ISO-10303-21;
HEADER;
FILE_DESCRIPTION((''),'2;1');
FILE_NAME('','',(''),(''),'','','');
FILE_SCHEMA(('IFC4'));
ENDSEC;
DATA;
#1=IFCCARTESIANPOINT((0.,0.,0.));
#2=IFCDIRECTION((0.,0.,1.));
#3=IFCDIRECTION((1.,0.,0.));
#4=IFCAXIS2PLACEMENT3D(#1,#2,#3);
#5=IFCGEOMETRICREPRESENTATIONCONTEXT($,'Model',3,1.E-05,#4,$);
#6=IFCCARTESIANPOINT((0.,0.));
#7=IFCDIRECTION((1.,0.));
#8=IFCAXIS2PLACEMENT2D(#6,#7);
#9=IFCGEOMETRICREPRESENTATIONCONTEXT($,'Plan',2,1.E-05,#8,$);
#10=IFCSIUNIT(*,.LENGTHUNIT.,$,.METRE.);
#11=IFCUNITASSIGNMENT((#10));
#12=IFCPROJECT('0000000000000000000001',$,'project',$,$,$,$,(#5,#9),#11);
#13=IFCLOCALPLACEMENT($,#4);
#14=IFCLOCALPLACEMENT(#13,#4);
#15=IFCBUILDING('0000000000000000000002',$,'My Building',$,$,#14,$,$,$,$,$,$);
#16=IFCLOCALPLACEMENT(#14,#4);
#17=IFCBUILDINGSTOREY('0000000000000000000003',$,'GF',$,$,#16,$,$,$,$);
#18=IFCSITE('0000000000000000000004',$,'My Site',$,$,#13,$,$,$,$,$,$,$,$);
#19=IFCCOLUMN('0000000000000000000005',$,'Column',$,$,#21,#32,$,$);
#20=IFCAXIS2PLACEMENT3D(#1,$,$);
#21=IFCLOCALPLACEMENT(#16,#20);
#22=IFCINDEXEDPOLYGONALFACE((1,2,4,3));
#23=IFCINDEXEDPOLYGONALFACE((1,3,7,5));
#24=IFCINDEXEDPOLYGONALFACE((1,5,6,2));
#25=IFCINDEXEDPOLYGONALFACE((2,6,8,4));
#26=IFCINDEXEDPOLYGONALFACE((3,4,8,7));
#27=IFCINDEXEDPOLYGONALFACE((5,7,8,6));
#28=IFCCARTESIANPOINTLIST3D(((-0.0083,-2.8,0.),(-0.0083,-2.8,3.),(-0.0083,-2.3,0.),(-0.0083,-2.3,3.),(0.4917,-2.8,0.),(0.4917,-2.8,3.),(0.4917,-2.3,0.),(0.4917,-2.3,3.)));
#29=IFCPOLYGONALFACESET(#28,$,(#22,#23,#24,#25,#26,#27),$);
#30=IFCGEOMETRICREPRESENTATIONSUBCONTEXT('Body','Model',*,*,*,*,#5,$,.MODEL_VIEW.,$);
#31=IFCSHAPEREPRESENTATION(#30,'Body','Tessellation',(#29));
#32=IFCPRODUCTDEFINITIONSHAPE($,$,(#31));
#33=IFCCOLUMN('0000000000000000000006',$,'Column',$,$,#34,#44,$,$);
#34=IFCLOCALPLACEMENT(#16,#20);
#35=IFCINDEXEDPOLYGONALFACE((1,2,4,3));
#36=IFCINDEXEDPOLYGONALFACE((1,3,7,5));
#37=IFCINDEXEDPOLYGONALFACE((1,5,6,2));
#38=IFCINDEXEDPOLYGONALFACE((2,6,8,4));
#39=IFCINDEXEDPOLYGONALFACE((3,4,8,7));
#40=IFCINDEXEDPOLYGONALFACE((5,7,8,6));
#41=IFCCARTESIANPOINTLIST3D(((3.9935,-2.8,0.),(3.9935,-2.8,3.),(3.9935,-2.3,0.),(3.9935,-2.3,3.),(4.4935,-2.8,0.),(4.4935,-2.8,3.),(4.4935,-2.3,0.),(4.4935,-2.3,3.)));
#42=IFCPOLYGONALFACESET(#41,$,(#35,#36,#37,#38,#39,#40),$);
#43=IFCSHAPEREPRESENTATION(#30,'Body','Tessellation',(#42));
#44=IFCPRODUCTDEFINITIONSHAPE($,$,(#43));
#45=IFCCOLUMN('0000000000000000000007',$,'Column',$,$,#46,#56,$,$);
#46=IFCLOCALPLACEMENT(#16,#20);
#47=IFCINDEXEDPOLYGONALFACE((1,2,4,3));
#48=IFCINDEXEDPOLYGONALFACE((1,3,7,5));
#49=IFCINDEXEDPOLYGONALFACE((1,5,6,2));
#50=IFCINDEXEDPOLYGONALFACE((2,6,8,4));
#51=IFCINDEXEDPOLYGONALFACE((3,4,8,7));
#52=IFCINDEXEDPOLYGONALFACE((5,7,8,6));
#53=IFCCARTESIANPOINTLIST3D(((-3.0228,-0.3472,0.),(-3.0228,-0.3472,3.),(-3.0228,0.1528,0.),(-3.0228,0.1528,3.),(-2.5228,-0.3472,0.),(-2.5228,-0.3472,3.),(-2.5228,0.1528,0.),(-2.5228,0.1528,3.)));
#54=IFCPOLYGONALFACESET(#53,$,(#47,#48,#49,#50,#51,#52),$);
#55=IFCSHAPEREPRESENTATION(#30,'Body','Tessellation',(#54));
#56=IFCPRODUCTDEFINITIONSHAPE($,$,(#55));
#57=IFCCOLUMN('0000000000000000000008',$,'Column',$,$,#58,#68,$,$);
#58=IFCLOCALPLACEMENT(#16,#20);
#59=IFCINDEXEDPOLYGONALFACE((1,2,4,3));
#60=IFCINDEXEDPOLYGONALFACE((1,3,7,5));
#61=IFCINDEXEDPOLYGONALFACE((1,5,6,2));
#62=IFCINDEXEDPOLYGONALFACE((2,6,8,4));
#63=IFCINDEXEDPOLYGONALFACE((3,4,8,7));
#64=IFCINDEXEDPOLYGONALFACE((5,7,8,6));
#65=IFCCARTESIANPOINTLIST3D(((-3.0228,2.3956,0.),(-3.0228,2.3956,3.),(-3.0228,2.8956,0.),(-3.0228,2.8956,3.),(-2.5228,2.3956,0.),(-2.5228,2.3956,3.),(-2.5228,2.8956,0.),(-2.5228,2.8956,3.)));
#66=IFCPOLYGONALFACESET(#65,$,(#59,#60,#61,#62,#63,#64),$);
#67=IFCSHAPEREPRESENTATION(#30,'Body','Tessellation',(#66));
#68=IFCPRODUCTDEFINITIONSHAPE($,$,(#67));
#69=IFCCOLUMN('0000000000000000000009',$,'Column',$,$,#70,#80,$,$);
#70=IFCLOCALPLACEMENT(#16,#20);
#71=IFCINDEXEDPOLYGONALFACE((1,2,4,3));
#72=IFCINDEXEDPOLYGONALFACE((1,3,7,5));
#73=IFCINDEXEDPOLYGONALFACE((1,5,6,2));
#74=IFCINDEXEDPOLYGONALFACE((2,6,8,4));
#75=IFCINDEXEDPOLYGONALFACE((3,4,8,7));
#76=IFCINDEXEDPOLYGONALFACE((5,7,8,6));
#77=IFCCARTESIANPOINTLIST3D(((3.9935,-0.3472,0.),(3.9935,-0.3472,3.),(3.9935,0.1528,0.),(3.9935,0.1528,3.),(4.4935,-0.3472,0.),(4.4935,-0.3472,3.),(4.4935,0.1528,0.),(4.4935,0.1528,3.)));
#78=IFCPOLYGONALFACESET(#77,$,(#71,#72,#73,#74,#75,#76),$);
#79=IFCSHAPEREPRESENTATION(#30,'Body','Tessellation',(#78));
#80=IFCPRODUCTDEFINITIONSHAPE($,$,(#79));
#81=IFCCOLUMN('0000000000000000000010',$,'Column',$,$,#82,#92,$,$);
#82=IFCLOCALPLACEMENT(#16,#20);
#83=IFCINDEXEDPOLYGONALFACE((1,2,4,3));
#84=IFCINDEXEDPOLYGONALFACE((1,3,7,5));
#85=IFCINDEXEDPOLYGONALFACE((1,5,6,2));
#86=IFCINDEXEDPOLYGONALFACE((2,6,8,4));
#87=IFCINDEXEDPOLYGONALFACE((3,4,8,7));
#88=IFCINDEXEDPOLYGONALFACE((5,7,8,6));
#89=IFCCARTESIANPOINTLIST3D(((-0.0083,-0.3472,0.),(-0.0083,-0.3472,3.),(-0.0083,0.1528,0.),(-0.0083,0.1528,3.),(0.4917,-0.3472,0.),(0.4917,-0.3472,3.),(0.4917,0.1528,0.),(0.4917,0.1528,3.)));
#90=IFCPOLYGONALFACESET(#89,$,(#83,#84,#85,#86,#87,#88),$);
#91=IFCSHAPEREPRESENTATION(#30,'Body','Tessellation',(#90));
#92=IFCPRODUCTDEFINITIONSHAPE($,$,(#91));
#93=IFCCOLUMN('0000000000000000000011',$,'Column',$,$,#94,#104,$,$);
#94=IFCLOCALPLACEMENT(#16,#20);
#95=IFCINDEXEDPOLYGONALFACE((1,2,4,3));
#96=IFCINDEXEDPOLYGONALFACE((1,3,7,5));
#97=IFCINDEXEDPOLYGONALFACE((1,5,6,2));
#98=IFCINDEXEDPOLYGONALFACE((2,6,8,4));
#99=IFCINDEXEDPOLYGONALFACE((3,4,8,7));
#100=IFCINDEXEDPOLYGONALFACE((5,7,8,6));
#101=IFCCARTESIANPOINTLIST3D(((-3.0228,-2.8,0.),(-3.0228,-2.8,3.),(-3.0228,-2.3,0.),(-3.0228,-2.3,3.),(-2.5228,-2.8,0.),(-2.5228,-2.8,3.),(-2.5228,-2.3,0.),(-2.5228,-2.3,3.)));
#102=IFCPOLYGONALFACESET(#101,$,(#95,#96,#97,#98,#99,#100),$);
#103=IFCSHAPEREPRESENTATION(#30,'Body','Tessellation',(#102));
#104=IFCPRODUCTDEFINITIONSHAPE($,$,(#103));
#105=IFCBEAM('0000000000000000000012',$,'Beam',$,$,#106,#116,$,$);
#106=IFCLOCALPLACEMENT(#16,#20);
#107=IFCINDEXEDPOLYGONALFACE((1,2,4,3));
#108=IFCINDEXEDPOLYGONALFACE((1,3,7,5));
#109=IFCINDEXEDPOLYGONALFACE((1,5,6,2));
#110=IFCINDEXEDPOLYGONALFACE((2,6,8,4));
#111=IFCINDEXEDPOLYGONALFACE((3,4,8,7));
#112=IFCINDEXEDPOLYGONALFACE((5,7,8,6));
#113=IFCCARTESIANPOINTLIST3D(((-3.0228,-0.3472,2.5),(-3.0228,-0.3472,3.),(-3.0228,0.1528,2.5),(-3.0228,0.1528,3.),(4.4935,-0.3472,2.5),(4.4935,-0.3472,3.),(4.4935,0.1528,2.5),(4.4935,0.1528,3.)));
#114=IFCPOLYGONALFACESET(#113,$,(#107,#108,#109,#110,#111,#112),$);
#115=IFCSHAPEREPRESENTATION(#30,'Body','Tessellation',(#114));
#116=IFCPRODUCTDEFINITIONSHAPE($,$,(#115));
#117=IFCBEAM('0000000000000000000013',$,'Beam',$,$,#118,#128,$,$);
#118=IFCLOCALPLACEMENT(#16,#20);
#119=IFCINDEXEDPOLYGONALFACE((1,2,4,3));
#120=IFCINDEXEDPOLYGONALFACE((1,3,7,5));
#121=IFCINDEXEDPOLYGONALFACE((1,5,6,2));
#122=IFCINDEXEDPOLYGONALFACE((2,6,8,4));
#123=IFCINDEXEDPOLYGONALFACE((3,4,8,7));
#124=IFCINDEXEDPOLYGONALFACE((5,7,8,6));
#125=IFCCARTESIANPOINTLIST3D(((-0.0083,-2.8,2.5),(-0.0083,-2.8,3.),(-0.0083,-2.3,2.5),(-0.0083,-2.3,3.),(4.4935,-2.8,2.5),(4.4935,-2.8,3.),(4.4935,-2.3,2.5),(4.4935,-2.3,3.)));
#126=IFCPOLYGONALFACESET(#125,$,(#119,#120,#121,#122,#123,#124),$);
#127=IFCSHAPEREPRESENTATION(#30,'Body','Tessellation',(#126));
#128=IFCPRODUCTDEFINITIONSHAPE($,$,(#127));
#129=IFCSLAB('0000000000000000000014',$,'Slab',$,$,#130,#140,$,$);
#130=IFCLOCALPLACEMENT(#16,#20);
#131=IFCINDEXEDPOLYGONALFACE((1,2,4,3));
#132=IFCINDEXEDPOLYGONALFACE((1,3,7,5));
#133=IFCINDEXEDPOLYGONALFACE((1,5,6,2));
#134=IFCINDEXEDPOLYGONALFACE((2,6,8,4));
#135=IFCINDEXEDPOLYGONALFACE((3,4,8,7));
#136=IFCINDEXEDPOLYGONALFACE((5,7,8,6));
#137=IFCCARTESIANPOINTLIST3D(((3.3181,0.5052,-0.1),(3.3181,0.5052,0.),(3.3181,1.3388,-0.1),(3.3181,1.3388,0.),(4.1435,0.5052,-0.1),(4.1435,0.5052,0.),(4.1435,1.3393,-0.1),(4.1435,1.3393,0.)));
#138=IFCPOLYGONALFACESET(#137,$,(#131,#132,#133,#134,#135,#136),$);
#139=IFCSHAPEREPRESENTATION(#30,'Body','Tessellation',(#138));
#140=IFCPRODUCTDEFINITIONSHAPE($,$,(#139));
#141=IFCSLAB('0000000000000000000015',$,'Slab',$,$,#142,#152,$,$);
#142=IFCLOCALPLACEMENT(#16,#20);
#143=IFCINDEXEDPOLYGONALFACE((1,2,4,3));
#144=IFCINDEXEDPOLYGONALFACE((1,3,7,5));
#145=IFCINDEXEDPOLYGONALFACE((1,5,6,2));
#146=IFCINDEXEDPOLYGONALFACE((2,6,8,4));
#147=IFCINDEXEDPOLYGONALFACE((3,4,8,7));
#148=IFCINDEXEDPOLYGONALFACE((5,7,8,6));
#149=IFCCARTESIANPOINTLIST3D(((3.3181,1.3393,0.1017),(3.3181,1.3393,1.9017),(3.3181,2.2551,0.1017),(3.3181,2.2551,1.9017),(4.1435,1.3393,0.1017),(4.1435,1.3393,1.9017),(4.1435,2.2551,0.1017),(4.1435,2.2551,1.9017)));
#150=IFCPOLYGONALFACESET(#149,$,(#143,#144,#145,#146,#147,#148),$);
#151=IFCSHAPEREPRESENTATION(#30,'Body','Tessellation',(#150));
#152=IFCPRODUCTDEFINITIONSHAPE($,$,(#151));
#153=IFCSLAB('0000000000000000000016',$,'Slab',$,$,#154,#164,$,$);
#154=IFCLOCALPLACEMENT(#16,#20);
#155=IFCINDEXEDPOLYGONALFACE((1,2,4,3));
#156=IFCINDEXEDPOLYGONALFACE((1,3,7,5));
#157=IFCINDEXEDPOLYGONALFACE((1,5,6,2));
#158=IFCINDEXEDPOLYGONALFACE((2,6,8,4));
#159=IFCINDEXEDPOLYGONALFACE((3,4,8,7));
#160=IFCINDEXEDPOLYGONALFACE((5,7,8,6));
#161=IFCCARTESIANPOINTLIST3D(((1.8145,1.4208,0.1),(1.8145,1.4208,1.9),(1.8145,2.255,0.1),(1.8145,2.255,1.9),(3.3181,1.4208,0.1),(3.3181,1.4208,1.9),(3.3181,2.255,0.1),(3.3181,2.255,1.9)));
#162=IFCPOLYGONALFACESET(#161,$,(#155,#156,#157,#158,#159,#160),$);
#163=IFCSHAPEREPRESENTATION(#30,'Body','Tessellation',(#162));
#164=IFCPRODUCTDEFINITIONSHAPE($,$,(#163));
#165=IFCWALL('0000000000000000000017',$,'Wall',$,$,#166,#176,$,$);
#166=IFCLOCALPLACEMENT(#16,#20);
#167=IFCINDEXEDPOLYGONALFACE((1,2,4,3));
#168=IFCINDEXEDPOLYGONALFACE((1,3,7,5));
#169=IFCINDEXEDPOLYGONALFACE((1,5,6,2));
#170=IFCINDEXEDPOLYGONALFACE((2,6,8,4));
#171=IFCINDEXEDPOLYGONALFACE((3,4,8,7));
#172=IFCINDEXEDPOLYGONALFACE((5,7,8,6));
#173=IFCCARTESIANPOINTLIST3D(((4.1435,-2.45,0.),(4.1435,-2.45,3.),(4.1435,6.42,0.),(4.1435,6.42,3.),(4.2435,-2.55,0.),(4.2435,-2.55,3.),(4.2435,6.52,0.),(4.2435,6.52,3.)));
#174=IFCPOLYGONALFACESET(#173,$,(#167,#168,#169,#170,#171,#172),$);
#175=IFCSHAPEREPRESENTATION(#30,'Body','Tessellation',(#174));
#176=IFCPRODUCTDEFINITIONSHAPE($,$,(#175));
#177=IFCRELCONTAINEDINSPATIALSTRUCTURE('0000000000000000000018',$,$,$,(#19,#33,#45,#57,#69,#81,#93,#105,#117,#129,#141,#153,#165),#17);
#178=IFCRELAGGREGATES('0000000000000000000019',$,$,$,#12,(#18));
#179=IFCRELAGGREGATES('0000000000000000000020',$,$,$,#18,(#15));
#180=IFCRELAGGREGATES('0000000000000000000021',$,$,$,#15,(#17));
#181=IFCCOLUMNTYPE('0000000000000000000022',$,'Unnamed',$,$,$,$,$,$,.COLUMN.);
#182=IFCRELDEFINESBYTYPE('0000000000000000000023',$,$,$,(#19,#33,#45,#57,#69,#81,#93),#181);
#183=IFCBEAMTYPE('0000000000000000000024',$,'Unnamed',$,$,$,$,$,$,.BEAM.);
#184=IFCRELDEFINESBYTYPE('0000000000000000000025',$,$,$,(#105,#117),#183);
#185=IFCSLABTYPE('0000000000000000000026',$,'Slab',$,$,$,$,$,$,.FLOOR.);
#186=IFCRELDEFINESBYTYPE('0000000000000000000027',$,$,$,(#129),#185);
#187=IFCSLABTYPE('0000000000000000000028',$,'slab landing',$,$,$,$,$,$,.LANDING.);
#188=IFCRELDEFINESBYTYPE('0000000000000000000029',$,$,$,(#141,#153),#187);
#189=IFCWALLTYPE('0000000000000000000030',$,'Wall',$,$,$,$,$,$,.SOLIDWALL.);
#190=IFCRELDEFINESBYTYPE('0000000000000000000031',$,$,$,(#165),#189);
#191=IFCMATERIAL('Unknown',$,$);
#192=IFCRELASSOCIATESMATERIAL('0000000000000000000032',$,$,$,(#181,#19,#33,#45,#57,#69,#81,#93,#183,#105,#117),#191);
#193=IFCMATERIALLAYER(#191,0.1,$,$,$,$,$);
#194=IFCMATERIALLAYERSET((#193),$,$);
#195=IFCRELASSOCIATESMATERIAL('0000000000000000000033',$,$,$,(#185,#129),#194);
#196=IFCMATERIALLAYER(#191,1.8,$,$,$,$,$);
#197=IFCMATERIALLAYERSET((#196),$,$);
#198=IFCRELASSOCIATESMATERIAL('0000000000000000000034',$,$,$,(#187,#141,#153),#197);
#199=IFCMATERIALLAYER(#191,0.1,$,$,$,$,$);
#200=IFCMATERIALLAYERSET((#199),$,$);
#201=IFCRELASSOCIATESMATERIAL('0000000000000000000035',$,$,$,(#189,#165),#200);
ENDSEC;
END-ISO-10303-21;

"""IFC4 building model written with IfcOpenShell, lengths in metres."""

from ifc_helpers import new_model, si_unit, frame, origin_with_axes, origin_2d_with_axis, place, context, subcontext, project, spatial, line, indexed_curve, rectangle, outline, extrude, material, layer, layer_set, layer_usage, material_profile, profile_set, profile_usage, type_object, element, save


model = new_model("IFC4")

# Units and contexts
model_context = context("Model", 3, precision=1e-05, world=origin_with_axes())
plan_context = context("Plan", 2, precision=1e-05, world=origin_2d_with_axis())
body_context_1 = subcontext(model_context, "Body", "Model", "MODEL_VIEW")
ifc_project = project(units=[si_unit("LENGTHUNIT", "METRE")], contexts=[model_context, plan_context])

# Site, building, storey
site_placement = place(None, origin_with_axes())
site = spatial("IfcSite", under=ifc_project, at=site_placement, Name="My Site")
building_placement = place(site_placement, origin_with_axes())
building = spatial("IfcBuilding", under=site, at=building_placement, Name="My Building")
storey_placement = place(building_placement, origin_with_axes())
storey = spatial("IfcBuildingStorey", under=building, at=storey_placement, Name="GF")

# Columns
ifc_material = material(Name="Unknown")
ifc_material_profile_1 = material_profile(ifc_material, rectangle(XDim=0.5, YDim=0.5))
ifc_profile_set_1 = profile_set([ifc_material_profile_1])
ifc_profile_usage_1 = profile_usage(ifc_profile_set_1, cardinal=5)
column_type = type_object("IfcColumnType", Name="Unnamed", PredefinedType="COLUMN", material=ifc_profile_set_1)
column_1_placement = place(storey_placement, frame((0.2417, -2.55, 0.0), z_axis=(0.0, 0.0, 1.0), x_axis=(1.0, 0.0, 0.0)))
element("IfcColumn", 1, at=column_1_placement, inside=storey, type_object=column_type, material=ifc_profile_usage_1, Name="Column", context=body_context_1, shape_type="SweptSolid", body=[
    extrude(rectangle(XDim=0.5, YDim=0.5), origin_with_axes(), (0.0, 0.0, 1.0), 3.0),
])
ifc_profile_usage_2 = profile_usage(ifc_profile_set_1, cardinal=5)
column_2_placement = place(storey_placement, frame((4.2435, -2.55, 0.0), z_axis=(0.0, 0.0, 1.0), x_axis=(1.0, 0.0, 0.0)))
element("IfcColumn", 2, at=column_2_placement, inside=storey, type_object=column_type, material=ifc_profile_usage_2, Name="Column", context=body_context_1, shape_type="SweptSolid", body=[
    extrude(rectangle(XDim=0.5, YDim=0.5), origin_with_axes(), (0.0, 0.0, 1.0), 3.0),
])
ifc_profile_usage_3 = profile_usage(ifc_profile_set_1, cardinal=5)
column_3_placement = place(storey_placement, frame((-2.7728, -0.0972, 0.0), z_axis=(0.0, 0.0, 1.0), x_axis=(1.0, 0.0, 0.0)))
element("IfcColumn", 3, at=column_3_placement, inside=storey, type_object=column_type, material=ifc_profile_usage_3, Name="Column", context=body_context_1, shape_type="SweptSolid", body=[
    extrude(rectangle(XDim=0.5, YDim=0.5), origin_with_axes(), (0.0, 0.0, 1.0), 3.0),
])
ifc_profile_usage_4 = profile_usage(ifc_profile_set_1, cardinal=5)
column_4_placement = place(storey_placement, frame((-2.7728, 2.6456, 0.0), z_axis=(0.0, 0.0, 1.0), x_axis=(1.0, 0.0, 0.0)))
element("IfcColumn", 4, at=column_4_placement, inside=storey, type_object=column_type, material=ifc_profile_usage_4, Name="Column", context=body_context_1, shape_type="SweptSolid", body=[
    extrude(rectangle(XDim=0.5, YDim=0.5), origin_with_axes(), (0.0, 0.0, 1.0), 3.0),
])
ifc_profile_usage_5 = profile_usage(ifc_profile_set_1, cardinal=5)
column_5_placement = place(storey_placement, frame((4.2435, -0.0972, 0.0), z_axis=(0.0, 0.0, 1.0), x_axis=(1.0, 0.0, 0.0)))
element("IfcColumn", 5, at=column_5_placement, inside=storey, type_object=column_type, material=ifc_profile_usage_5, Name="Column", context=body_context_1, shape_type="SweptSolid", body=[
    extrude(rectangle(XDim=0.5, YDim=0.5), origin_with_axes(), (0.0, 0.0, 1.0), 3.0),
])
ifc_profile_usage_6 = profile_usage(ifc_profile_set_1, cardinal=5)
column_6_placement = place(storey_placement, frame((0.2417, -0.0972, 0.0), z_axis=(0.0, 0.0, 1.0), x_axis=(1.0, 0.0, 0.0)))
element("IfcColumn", 6, at=column_6_placement, inside=storey, type_object=column_type, material=ifc_profile_usage_6, Name="Column", context=body_context_1, shape_type="SweptSolid", body=[
    extrude(rectangle(XDim=0.5, YDim=0.5), origin_with_axes(), (0.0, 0.0, 1.0), 3.0),
])
ifc_profile_usage_7 = profile_usage(ifc_profile_set_1, cardinal=5)
column_7_placement = place(storey_placement, frame((-2.7728, -2.55, 0.0), z_axis=(0.0, 0.0, 1.0), x_axis=(1.0, 0.0, 0.0)))
element("IfcColumn", 7, at=column_7_placement, inside=storey, type_object=column_type, material=ifc_profile_usage_7, Name="Column", context=body_context_1, shape_type="SweptSolid", body=[
    extrude(rectangle(XDim=0.5, YDim=0.5), origin_with_axes(), (0.0, 0.0, 1.0), 3.0),
])

# Beams
ifc_material_profile_2 = material_profile(ifc_material, rectangle(XDim=0.5, YDim=0.5))
ifc_profile_set_2 = profile_set([ifc_material_profile_2])
ifc_profile_usage_8 = profile_usage(ifc_profile_set_2, cardinal=7)
beam_type = type_object("IfcBeamType", Name="Unnamed", PredefinedType="BEAM", material=ifc_profile_set_2)
beam_1_placement = place(storey_placement, frame((-3.0228, 0.1528, 3.0), z_axis=(1.0, 0.0, 0.0), x_axis=(0.0, 1.0, 0.0)))
element("IfcBeam", 8, at=beam_1_placement, inside=storey, type_object=beam_type, material=ifc_profile_usage_8, Name="Beam", context=body_context_1, shape_type="SweptSolid", body=[
    extrude(rectangle(XDim=0.5, YDim=0.5), frame((-0.25, -0.25, 0.0), z_axis=(0.0, 0.0, 1.0), x_axis=(1.0, 0.0, 0.0)), (0.0, 0.0, 1.0), 7.5163),
])
ifc_profile_usage_9 = profile_usage(ifc_profile_set_2, cardinal=7)
beam_2_placement = place(storey_placement, frame((4.4935, -2.8, 3.0), z_axis=(-1.0, 0.0, 0.0), x_axis=(0.0, -1.0, 0.0)))
element("IfcBeam", 9, at=beam_2_placement, inside=storey, type_object=beam_type, material=ifc_profile_usage_9, Name="Beam", context=body_context_1, shape_type="SweptSolid", body=[
    extrude(rectangle(XDim=0.5, YDim=0.5), frame((-0.25, -0.25, 0.0), z_axis=(0.0, 0.0, 1.0), x_axis=(1.0, 0.0, 0.0)), (0.0, 0.0, 1.0), 4.5018),
])

# Slabs
ifc_layer_1 = layer(ifc_material, 0.1)
ifc_layer_set_1 = layer_set([ifc_layer_1])
ifc_layer_usage_1 = layer_usage(ifc_layer_set_1, "AXIS3", "POSITIVE", -0.1)
slab_type_1 = type_object("IfcSlabType", Name="Slab", PredefinedType="FLOOR", material=ifc_layer_set_1)
slab_1_placement = place(storey_placement, frame((3.3181, 1.3388, 0.0), z_axis=(0.0, 0.0, 1.0), x_axis=(1.0, 0.0, 0.0)))
element("IfcSlab", 10, at=slab_1_placement, inside=storey, type_object=slab_type_1, material=ifc_layer_usage_1, Name="Slab", context=body_context_1, shape_type="SweptSolid", body=[
    extrude(outline(indexed_curve([(0.0, 0.0), (0.0, -0.8336), (0.8254, -0.8336), (0.8254, 0.0005), (0.0, 0.0)])), frame((0.0, 0.0, -0.1), z_axis=(0.0, 0.0, 1.0), x_axis=(1.0, 0.0, 0.0)), (0.0, 0.0, 1.0), 0.1),
])
ifc_layer_2 = layer(ifc_material, 1.8)
ifc_layer_set_2 = layer_set([ifc_layer_2])
slab_type_2 = type_object("IfcSlabType", Name="slab landing", PredefinedType="LANDING", material=ifc_layer_set_2)
ifc_layer_usage_2 = layer_usage(ifc_layer_set_2, "AXIS3", "POSITIVE", -1.8)
slab_2_placement = place(storey_placement, frame((4.1435, 1.3393, 1.9017), z_axis=(0.0, 0.0, 1.0), x_axis=(1.0, 0.0, 0.0)))
element("IfcSlab", 11, at=slab_2_placement, inside=storey, type_object=slab_type_2, material=ifc_layer_usage_2, Name="Slab", context=body_context_1, shape_type="SweptSolid", body=[
    extrude(outline(indexed_curve([(0.0, 0.0), (0.0, 0.9157), (-0.8254, 0.9157), (-0.8254, 0.0), (0.0, 0.0)])), frame((0.0, 0.0, -1.8), z_axis=(0.0, 0.0, 1.0), x_axis=(1.0, 0.0, 0.0)), (0.0, 0.0, 1.0), 1.8),
])
ifc_layer_usage_3 = layer_usage(ifc_layer_set_2, "AXIS3", "POSITIVE", -1.8)
slab_3_placement = place(storey_placement, frame((3.3181, 1.4208, 1.9), z_axis=(0.0, 0.0, 1.0), x_axis=(1.0, 0.0, 0.0)))
element("IfcSlab", 12, at=slab_3_placement, inside=storey, type_object=slab_type_2, material=ifc_layer_usage_3, Name="Slab", context=body_context_1, shape_type="SweptSolid", body=[
    extrude(outline(indexed_curve([(0.0, 0.0), (-1.5036, 0.0), (-1.5036, 0.8342), (0.0, 0.8342), (0.0, 0.0)])), frame((0.0, 0.0, -1.8), z_axis=(0.0, 0.0, 1.0), x_axis=(1.0, 0.0, 0.0)), (0.0, 0.0, 1.0), 1.8),
])

# Shared definitions
ifc_layer_3 = layer(ifc_material, 0.1)
ifc_layer_set_3 = layer_set([ifc_layer_3])
wall_type = type_object("IfcWallType", Name="Wall", PredefinedType="SOLIDWALL", material=ifc_layer_set_3)

# Wall
ifc_layer_usage_4 = layer_usage(ifc_layer_set_3, "AXIS2", "POSITIVE", 0.0)
wall_1_placement = place(storey_placement, frame((4.2435, -2.45, 0.0), z_axis=(0.0, 0.0, 1.0), x_axis=(0.0, 1.0, 0.0)))
element("IfcWall", 13, at=wall_1_placement, inside=storey, type_object=wall_type, material=ifc_layer_usage_4, Name="Wall", context=body_context_1, shape_type="SweptSolid", body=[
    extrude(outline(indexed_curve([(-0.1, 0.0), (0.0, 0.1), (8.87, 0.1), (8.97, 0.0)], segments=[line(1, 2, 3, 4, 1)])), origin_with_axes(), (0.0, 0.0, 1.0), 3.0),
])

save(model, "model.ifc")
